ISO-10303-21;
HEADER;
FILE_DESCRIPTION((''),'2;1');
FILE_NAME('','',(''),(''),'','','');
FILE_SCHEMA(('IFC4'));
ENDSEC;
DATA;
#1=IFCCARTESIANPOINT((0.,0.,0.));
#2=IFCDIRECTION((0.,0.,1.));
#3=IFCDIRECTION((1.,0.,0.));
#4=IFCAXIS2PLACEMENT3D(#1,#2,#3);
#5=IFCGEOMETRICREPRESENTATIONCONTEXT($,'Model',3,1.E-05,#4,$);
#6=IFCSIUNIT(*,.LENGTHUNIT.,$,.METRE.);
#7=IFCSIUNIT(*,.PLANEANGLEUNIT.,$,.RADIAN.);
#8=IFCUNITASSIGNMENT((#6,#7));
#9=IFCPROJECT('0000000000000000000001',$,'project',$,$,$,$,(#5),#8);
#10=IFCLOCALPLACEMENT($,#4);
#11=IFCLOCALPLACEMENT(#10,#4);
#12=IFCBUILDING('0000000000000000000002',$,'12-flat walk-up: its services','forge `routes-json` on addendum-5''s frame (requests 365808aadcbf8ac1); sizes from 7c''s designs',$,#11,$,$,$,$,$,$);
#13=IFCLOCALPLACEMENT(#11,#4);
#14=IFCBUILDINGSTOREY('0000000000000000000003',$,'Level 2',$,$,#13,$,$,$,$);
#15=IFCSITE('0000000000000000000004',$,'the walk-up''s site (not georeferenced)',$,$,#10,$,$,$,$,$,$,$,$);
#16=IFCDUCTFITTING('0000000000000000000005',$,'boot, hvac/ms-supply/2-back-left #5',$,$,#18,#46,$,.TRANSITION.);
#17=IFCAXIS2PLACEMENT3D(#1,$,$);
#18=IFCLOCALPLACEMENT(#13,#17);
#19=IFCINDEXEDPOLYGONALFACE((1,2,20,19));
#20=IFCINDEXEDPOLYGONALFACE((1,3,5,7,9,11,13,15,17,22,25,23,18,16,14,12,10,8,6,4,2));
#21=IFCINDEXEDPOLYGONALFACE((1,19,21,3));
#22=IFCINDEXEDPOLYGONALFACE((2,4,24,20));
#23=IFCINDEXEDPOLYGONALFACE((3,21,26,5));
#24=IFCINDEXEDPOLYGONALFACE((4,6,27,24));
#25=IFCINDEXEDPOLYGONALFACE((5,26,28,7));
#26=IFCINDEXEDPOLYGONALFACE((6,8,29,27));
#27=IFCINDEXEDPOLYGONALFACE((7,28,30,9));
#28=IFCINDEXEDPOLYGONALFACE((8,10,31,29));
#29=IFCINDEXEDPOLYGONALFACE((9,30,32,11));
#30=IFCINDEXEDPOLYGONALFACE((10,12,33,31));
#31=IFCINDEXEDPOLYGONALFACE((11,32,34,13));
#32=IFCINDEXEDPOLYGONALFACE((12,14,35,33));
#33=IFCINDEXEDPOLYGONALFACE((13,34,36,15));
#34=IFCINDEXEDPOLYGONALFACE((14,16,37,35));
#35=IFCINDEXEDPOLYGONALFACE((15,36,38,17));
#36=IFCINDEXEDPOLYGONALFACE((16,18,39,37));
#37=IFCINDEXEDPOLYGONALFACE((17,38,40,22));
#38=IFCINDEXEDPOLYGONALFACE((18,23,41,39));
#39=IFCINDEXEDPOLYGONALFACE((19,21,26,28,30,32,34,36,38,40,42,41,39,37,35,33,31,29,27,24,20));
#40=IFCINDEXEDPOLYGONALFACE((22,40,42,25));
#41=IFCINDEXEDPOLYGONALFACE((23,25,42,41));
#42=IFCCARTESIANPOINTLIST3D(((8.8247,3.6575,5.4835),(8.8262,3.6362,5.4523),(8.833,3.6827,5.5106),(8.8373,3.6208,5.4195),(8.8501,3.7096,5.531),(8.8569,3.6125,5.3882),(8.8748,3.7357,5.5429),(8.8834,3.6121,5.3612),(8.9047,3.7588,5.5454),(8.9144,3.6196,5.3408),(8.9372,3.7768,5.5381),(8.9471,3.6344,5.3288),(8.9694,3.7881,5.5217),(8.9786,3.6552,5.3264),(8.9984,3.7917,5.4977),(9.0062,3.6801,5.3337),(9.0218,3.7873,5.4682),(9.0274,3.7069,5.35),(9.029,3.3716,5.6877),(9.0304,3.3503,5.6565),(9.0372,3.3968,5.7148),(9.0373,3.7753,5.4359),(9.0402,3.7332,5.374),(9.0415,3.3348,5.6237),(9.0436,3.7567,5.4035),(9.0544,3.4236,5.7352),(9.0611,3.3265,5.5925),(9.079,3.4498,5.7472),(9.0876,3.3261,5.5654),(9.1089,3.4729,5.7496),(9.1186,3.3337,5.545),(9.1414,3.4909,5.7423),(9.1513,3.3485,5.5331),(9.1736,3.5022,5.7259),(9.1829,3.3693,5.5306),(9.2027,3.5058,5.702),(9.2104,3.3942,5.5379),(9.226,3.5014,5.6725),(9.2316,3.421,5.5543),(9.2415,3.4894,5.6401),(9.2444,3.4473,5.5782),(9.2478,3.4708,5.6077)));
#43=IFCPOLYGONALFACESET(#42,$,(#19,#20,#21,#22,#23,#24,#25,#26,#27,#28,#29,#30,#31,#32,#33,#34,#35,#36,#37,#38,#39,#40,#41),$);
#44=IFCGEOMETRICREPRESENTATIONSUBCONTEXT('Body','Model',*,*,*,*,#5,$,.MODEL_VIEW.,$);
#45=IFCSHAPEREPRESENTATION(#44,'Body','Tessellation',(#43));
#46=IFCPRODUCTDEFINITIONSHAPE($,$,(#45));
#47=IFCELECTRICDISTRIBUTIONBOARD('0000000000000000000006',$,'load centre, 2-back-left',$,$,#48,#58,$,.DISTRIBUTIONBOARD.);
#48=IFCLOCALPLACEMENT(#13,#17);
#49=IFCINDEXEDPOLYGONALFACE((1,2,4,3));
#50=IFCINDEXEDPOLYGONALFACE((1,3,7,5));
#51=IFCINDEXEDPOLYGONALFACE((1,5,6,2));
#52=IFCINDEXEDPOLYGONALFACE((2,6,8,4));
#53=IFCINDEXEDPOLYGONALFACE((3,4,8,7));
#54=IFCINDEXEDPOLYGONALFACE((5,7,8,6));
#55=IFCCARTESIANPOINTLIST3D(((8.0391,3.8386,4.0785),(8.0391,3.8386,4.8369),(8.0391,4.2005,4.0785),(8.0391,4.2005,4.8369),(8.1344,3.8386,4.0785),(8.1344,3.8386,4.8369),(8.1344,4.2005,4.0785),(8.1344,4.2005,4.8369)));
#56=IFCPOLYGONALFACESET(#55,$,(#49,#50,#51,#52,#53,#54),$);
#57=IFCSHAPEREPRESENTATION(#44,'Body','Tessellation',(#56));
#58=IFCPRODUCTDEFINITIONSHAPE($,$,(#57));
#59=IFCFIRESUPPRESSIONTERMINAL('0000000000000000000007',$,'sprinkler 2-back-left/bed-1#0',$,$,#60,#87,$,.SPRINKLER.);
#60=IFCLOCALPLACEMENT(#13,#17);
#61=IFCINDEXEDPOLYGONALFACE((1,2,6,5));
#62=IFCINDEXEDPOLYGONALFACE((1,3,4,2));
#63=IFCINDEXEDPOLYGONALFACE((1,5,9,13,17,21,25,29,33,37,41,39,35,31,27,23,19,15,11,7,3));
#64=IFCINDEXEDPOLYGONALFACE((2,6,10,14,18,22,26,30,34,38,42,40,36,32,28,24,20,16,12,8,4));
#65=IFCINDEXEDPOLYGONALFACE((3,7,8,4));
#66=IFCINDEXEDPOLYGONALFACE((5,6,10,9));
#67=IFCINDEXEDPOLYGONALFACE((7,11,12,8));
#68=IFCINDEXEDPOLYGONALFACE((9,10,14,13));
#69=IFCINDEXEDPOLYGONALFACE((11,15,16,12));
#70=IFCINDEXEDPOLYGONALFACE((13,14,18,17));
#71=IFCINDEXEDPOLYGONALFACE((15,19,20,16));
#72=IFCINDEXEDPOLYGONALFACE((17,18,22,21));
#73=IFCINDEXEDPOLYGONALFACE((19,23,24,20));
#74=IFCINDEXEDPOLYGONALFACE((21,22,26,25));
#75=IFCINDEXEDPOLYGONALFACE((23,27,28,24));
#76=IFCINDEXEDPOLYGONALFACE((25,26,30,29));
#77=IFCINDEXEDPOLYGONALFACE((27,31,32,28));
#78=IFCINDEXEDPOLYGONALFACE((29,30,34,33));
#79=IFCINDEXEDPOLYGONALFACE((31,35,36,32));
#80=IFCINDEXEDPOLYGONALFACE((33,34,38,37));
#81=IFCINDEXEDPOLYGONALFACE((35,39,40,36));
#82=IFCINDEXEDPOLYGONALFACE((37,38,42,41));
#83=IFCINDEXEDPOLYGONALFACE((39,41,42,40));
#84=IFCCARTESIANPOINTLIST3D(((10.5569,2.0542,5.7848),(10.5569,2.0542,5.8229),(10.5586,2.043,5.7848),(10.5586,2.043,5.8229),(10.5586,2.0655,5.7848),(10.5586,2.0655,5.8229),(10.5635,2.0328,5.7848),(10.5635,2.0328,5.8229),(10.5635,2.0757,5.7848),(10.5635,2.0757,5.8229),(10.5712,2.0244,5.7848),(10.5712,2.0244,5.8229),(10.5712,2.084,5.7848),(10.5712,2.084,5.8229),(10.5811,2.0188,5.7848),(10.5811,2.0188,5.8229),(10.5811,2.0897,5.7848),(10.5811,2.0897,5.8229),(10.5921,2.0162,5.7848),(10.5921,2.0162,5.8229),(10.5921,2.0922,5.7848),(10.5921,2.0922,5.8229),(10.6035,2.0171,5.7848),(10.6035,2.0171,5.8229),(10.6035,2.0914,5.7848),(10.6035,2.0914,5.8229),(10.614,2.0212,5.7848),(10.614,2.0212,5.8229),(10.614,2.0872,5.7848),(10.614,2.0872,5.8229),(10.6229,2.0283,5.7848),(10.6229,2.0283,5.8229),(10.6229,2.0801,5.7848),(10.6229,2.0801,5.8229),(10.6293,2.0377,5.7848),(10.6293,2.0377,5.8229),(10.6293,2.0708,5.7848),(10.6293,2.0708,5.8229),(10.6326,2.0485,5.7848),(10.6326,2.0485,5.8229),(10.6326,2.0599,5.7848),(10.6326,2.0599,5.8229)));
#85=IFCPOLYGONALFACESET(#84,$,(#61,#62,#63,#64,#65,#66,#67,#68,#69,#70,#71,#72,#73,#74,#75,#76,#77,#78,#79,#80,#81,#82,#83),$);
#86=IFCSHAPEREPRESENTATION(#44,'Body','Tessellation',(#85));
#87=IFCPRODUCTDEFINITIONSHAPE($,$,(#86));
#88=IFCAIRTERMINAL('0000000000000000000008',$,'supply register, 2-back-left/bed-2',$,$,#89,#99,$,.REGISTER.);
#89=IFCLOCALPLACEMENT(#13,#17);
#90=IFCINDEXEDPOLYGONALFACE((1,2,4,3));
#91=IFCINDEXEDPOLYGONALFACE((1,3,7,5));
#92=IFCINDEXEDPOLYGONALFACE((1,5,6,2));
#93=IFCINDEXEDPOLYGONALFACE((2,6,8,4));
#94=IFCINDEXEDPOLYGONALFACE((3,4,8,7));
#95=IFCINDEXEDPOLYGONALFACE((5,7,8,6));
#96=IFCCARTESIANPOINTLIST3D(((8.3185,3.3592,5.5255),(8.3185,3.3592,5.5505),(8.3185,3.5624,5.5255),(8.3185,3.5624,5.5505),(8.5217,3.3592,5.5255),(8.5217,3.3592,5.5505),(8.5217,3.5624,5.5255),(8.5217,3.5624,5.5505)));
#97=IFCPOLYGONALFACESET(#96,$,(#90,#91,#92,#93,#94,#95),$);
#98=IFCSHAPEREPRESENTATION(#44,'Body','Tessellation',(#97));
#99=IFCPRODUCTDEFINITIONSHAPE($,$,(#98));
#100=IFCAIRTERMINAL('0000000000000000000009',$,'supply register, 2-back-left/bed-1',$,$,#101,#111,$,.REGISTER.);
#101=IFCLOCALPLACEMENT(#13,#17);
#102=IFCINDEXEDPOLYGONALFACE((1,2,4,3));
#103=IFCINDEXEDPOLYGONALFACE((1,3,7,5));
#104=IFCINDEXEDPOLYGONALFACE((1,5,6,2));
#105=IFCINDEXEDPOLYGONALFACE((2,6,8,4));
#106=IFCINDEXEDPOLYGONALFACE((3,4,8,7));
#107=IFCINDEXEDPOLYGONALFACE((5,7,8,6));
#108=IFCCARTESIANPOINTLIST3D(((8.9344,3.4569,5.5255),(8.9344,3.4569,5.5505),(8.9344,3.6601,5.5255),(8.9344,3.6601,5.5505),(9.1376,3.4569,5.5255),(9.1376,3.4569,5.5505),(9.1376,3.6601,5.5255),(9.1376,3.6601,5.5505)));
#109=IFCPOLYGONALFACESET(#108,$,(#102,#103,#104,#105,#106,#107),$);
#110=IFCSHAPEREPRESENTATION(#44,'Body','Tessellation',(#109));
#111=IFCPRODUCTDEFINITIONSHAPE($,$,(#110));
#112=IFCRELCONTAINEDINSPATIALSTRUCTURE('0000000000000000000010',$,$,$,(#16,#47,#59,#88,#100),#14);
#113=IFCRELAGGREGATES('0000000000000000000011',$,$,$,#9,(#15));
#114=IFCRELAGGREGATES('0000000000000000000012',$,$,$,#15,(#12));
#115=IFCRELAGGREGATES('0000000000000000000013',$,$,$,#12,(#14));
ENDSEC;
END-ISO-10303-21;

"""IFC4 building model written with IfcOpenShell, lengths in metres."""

from ifc_helpers import new_model, entity, si_unit, frame, frame_2d, origin, origin_with_axes, place, context, subcontext, project, spatial, rectangle, extrude, element, save


model = new_model("IFC4")

# Units and contexts
model_context = context("Model", 3, precision=1e-05, world=origin_with_axes())
body_context = subcontext(model_context, "Body", "Model", "MODEL_VIEW")
ifc_project = project(units=[si_unit("LENGTHUNIT", "METRE"), si_unit("PLANEANGLEUNIT", "RADIAN")], contexts=[model_context])

# Site, building, storey
site_placement = place(None, origin_with_axes())
site = spatial("IfcSite", under=ifc_project, at=site_placement, Name="the walk-up's site (not georeferenced)")
building_placement = place(site_placement, origin_with_axes())
building = spatial("IfcBuilding", under=site, at=building_placement, Name="12-flat walk-up: its services", Description="forge `routes-json` on addendum-5's frame (requests 365808aadcbf8ac1); sizes from 7c's designs")
storey_placement = place(building_placement, origin_with_axes())
storey = spatial("IfcBuildingStorey", under=building, at=storey_placement, Name="Level 2")

# Duct fitting
duct_fitting_1_placement = place(storey_placement, frame((9.1382, 3.4156, 5.6401), z_axis=(0.0, 0.0, 1.0), x_axis=(1.0, 0.0, 0.0)))
element("IfcDuctFitting", 1, at=duct_fitting_1_placement, inside=storey, Name="boot, hvac/ms-supply/2-back-left #5", PredefinedType="TRANSITION", context=body_context, shape_type="AdvancedSweptSolid", body=[
    entity("IfcSweptDiskSolid", entity("IfcPolyline", [entity("IfcCartesianPoint", [0.0, 0.0, 0.0]), entity("IfcCartesianPoint", [-0.2042, 0.2859, -0.2042])]), 0.127),
])

# Electric distribution board
electric_distribution_board_placement = place(storey_placement, frame((8.0391, 3.8386, 4.0785), z_axis=(0.0, 0.0, 1.0), x_axis=(1.0, 0.0, 0.0)))
element("IfcElectricDistributionBoard", 2, at=electric_distribution_board_placement, inside=storey, Name="load centre, 2-back-left", PredefinedType="DISTRIBUTIONBOARD", context=body_context, shape_type="SweptSolid", body=[
    extrude(rectangle(XDim=0.0953, YDim=0.362, at=frame_2d((0.0476, 0.181))), origin(), (0.0, 0.0, 1.0), 0.7584),
])

# Fire suppression terminal
fire_suppression_terminal_placement = place(storey_placement, frame((10.595, 2.0542, 5.8229), z_axis=(0.0, 0.0, 1.0), x_axis=(1.0, 0.0, 0.0)))
element("IfcFireSuppressionTerminal", 3, at=fire_suppression_terminal_placement, inside=storey, Name="sprinkler 2-back-left/bed-1#0", PredefinedType="SPRINKLER", context=body_context, shape_type="AdvancedSweptSolid", body=[
    entity("IfcSweptDiskSolid", entity("IfcPolyline", [entity("IfcCartesianPoint", [0.0, 0.0, 0.0]), entity("IfcCartesianPoint", [0.0, 0.0, -0.0381])]), 0.0381),
])

# Air terminals
for number, where, z_axis, x_axis, name in (
    (4, (8.3185, 3.3592, 5.5255), (0.0, 0.0, 1.0), (1.0, 0.0, 0.0), "supply register, 2-back-left/bed-2"),
    (5, (8.9345, 3.4569, 5.5255), (0.0, 0.0, 1.0), (1.0, 0.0, 0.0), "supply register, 2-back-left/bed-1"),
):
    element("IfcAirTerminal", number, at=place(storey_placement, frame(where, z_axis=z_axis, x_axis=x_axis)), inside=storey, Name=name, PredefinedType="REGISTER", context=body_context, shape_type="SweptSolid", body=[
        extrude(rectangle(XDim=0.2032, YDim=0.2032, at=frame_2d((0.1016, 0.1016))), origin(), (0.0, 0.0, 1.0), 0.025),
    ])

save(model, "model.ifc")
